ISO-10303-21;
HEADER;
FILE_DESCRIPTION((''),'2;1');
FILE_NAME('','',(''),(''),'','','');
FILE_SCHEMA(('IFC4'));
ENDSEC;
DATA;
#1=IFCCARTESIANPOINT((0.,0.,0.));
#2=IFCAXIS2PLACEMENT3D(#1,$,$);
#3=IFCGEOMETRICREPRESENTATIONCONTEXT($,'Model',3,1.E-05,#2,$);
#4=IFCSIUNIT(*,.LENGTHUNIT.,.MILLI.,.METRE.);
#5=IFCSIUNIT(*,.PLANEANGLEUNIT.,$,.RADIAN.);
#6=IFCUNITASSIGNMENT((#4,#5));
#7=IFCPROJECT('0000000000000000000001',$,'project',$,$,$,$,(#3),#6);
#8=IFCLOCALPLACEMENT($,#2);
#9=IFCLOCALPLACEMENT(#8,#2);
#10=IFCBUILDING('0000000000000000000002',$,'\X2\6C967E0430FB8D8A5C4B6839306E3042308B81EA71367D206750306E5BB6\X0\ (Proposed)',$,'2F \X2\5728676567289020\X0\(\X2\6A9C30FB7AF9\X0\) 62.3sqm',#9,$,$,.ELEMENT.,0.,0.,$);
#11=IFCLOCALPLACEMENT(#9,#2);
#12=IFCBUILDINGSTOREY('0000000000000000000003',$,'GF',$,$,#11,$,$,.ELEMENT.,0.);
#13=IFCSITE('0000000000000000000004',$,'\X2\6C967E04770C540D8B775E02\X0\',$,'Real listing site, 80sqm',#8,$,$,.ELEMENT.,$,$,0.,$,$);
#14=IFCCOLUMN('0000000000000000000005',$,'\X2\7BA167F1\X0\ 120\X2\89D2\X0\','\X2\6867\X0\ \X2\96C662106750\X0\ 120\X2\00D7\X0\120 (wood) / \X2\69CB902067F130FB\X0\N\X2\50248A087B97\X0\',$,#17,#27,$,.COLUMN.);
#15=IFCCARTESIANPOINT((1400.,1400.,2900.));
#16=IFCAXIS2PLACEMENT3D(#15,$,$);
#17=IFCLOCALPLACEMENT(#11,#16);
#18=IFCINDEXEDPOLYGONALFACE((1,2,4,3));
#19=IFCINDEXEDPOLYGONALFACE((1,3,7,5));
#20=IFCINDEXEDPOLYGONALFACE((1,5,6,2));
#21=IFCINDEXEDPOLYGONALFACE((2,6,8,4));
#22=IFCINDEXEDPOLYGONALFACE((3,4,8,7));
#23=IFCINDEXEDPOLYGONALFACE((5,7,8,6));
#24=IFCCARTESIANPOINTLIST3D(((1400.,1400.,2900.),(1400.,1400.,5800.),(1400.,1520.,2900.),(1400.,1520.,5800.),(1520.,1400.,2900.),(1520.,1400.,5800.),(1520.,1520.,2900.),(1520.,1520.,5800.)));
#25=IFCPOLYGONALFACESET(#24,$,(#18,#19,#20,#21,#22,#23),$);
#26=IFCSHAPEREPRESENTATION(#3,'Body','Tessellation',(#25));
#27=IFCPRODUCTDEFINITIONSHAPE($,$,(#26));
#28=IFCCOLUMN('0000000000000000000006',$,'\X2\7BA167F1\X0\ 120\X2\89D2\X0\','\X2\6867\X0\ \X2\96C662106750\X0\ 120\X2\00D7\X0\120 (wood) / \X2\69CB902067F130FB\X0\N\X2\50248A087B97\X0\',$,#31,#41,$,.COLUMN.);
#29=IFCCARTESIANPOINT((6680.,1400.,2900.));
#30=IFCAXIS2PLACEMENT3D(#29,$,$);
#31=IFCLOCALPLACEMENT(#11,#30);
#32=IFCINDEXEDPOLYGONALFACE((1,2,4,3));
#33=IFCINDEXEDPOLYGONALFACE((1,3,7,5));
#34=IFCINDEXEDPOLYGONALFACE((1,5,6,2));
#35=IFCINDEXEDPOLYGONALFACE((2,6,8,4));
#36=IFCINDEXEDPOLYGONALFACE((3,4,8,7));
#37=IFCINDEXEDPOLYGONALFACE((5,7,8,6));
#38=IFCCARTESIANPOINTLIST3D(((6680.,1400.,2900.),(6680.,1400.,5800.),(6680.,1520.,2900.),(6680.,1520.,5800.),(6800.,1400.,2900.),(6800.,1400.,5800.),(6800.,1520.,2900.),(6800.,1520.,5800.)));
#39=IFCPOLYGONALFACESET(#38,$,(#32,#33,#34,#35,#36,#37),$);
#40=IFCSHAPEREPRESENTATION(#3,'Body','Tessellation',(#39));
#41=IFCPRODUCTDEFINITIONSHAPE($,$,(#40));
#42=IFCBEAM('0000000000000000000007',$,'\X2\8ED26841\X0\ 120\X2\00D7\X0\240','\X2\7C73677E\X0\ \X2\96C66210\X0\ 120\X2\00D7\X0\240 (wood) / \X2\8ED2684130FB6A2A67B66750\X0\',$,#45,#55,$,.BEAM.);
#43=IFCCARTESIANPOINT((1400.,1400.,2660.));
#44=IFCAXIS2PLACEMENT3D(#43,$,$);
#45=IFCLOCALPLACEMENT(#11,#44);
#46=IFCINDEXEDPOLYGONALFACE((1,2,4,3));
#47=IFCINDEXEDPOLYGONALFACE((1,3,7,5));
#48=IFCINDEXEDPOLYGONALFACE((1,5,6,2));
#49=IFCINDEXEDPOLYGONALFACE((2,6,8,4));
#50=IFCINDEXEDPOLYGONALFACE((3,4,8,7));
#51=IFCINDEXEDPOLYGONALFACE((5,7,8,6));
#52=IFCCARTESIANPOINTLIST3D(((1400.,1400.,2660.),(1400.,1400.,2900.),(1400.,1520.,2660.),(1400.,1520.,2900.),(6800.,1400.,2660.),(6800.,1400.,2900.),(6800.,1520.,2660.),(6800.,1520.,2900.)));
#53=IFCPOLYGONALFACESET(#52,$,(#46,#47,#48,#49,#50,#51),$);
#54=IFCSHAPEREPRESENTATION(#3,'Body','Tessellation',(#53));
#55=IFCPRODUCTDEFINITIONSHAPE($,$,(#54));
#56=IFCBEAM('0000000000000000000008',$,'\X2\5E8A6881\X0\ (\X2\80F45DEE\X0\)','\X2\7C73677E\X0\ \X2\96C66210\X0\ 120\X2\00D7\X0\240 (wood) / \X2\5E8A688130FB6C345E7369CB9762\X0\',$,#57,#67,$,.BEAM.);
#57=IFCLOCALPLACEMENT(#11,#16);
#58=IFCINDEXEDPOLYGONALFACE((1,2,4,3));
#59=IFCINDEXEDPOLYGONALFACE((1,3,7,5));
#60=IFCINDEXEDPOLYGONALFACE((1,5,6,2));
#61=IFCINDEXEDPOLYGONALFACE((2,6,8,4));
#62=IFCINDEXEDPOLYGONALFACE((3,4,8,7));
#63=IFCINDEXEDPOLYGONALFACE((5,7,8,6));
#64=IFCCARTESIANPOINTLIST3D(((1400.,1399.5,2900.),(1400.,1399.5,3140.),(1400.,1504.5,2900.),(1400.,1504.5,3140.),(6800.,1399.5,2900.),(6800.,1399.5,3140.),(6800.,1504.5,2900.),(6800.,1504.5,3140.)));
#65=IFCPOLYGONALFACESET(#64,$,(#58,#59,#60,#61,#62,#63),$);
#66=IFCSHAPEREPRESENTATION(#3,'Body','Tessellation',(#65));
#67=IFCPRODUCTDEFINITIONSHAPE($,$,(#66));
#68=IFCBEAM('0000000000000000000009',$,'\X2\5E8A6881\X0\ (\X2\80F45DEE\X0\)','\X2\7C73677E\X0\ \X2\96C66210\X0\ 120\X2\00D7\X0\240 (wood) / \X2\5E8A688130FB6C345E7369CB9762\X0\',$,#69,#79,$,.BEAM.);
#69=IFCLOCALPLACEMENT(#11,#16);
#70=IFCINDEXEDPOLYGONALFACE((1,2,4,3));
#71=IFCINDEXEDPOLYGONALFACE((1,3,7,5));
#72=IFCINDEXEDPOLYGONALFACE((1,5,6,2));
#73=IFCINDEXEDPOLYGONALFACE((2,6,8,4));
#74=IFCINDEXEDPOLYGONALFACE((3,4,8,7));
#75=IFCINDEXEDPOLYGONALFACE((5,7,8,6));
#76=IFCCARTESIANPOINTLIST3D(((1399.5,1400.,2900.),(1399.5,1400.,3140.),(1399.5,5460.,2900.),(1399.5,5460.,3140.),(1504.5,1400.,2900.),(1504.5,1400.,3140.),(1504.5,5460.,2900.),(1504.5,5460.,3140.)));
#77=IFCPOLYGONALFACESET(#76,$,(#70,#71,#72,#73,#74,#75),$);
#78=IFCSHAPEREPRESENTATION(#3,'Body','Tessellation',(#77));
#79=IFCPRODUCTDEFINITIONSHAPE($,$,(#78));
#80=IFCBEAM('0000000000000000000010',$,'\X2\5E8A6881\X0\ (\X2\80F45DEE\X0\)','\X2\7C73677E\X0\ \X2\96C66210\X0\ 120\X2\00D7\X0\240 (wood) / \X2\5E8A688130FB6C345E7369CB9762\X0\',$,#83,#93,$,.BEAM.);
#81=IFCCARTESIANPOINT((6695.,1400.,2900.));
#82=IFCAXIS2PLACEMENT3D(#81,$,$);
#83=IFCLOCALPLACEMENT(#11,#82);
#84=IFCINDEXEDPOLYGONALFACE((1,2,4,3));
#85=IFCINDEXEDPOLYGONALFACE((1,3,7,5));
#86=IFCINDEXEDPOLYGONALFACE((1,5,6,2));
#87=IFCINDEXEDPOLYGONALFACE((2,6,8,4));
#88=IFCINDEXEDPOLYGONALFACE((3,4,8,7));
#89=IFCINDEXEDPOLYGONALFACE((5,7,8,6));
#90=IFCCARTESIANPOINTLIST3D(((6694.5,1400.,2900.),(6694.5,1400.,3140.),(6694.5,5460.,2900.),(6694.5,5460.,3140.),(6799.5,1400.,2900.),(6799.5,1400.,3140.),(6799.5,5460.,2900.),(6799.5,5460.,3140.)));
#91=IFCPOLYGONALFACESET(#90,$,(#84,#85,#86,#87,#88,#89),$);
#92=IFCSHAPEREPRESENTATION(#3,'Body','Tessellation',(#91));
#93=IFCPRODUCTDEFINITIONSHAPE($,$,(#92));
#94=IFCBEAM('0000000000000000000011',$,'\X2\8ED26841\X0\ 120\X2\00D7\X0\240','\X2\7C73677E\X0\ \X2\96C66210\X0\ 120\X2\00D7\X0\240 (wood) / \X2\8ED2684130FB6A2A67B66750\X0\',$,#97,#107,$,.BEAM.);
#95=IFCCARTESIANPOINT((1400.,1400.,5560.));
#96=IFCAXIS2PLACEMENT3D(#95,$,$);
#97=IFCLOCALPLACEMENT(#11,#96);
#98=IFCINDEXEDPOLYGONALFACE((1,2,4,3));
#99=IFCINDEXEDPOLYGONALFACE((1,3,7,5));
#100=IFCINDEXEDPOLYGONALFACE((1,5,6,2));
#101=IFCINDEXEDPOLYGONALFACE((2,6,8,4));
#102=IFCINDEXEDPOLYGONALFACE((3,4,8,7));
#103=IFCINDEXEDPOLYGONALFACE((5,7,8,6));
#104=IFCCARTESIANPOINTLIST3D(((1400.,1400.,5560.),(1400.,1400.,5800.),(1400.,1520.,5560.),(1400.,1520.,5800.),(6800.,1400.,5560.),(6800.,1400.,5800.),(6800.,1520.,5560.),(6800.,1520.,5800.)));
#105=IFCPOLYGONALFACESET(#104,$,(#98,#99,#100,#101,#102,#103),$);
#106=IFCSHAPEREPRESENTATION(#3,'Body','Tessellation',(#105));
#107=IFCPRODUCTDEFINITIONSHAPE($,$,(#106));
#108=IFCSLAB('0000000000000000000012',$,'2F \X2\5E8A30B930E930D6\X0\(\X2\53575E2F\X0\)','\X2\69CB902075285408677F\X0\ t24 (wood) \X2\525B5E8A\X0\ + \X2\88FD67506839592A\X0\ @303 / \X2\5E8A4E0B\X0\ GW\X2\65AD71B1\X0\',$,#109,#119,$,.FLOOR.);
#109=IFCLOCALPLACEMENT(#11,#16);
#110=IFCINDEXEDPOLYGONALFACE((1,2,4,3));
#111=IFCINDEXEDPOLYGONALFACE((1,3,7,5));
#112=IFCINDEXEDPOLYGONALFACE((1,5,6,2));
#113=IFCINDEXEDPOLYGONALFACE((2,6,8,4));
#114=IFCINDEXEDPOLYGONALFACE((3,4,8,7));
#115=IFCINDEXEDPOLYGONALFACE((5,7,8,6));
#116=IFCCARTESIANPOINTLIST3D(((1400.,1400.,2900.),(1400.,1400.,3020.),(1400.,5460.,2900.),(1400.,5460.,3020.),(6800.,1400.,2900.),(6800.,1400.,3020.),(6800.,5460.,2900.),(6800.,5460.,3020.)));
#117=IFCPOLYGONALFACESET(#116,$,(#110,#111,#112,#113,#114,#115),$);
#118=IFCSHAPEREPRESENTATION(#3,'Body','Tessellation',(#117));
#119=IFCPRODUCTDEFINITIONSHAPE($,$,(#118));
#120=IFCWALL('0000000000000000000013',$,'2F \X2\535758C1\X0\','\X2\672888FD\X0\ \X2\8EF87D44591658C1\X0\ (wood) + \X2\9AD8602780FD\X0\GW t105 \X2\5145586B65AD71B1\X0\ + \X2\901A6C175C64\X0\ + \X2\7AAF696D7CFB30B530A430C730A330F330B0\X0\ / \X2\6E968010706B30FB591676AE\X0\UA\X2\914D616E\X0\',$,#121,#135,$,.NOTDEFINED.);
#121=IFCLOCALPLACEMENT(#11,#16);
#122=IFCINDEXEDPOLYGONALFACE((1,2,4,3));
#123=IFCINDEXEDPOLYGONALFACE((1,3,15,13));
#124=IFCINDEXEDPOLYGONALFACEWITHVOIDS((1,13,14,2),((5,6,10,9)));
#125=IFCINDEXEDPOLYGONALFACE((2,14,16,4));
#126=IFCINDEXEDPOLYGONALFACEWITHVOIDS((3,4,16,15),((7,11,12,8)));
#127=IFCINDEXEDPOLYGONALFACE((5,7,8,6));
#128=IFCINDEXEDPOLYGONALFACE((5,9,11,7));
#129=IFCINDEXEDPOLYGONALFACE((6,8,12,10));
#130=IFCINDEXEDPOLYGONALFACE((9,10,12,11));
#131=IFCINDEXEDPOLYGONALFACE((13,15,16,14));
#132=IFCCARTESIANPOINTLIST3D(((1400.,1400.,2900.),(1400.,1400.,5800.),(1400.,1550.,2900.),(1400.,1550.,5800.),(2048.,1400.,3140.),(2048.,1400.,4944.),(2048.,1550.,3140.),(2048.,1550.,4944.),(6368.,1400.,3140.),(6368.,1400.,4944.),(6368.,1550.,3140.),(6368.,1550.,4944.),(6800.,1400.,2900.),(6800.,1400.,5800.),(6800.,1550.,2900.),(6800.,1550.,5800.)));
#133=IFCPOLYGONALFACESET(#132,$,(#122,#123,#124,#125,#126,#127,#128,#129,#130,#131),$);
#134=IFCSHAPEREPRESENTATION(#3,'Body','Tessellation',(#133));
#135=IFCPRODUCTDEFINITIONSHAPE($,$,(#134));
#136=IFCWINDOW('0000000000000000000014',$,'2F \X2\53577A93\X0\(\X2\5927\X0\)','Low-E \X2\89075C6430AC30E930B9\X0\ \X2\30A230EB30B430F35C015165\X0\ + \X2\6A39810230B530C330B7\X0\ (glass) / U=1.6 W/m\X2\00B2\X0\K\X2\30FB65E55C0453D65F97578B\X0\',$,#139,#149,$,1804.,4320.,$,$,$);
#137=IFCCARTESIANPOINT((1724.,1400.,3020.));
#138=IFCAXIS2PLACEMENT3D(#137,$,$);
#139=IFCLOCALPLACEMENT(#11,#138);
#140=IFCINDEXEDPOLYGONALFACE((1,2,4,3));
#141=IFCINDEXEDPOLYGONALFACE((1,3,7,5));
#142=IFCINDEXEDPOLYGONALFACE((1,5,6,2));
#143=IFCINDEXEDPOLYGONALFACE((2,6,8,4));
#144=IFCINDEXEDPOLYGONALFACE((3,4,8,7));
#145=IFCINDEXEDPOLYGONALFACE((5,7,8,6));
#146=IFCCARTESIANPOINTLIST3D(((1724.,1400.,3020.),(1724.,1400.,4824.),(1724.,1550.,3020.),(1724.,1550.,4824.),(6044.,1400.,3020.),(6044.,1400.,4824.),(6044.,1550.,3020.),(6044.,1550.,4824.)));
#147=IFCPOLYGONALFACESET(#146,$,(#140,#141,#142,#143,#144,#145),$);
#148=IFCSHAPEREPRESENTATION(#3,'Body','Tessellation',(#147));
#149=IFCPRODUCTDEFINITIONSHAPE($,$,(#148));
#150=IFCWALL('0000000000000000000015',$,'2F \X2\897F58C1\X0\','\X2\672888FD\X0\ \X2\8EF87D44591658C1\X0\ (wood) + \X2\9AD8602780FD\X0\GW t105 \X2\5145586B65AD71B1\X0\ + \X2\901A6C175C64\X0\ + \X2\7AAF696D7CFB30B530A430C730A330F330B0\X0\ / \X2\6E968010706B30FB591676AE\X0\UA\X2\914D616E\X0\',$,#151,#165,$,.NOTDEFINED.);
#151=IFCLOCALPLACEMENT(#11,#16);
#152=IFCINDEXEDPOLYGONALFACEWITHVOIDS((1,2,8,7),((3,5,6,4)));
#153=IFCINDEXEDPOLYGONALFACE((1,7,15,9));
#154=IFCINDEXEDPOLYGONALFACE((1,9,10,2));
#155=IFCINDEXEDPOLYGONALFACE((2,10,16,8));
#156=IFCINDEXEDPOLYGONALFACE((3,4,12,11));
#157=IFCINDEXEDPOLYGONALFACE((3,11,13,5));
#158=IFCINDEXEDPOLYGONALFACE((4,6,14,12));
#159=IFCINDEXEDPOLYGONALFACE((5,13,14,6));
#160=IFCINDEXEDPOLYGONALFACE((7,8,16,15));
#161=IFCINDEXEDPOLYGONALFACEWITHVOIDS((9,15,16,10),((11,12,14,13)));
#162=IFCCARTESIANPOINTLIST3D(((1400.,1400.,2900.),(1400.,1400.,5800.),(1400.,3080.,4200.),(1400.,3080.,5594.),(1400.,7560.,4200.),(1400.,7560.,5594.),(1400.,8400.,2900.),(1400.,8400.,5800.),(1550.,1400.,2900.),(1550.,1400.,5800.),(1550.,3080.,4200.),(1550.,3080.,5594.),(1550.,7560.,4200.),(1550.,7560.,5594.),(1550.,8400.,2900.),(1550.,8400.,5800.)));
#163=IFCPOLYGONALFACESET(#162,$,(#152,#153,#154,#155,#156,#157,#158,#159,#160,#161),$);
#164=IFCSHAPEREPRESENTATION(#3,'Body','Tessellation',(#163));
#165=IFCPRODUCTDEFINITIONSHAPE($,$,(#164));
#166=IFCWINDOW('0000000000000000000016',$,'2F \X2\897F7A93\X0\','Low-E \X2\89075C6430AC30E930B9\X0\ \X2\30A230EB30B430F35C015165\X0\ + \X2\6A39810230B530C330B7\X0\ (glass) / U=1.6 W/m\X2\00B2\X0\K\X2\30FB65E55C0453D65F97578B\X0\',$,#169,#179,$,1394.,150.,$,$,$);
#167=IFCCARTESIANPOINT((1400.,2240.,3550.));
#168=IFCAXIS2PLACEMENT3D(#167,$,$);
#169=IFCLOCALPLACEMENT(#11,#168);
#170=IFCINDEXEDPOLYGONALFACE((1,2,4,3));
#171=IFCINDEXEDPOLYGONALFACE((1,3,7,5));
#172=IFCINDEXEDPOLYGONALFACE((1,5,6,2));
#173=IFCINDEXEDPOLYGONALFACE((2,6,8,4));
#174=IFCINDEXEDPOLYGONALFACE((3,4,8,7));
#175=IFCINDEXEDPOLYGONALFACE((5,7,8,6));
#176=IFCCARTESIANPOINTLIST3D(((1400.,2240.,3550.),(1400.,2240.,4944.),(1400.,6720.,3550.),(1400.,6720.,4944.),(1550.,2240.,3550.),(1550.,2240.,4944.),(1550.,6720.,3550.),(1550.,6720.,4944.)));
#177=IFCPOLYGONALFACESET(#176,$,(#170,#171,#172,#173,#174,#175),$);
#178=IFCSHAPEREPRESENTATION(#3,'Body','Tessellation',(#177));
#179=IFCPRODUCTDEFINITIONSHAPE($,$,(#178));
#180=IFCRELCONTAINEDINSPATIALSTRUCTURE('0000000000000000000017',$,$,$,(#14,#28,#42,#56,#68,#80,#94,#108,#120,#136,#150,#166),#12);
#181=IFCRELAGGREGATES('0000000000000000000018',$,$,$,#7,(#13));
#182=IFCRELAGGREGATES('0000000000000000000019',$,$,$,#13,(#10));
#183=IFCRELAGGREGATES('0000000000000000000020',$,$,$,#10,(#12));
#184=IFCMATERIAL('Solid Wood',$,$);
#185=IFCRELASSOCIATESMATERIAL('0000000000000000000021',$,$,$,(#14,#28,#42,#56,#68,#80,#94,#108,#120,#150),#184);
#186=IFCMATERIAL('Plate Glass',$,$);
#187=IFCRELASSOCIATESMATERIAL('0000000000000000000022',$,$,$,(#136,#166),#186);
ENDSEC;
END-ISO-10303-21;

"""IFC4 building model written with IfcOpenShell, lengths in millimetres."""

from ifc_helpers import new_model, si_unit, frame, frame_2d, origin, place, context, project, spatial, rectangle, extrude, material, element, fill, save


model = new_model("IFC4")

# Units and contexts
model_context = context("Model", 3, precision=1e-05, world=origin())
ifc_project = project(units=[si_unit("LENGTHUNIT", "METRE", prefix="MILLI"), si_unit("PLANEANGLEUNIT", "RADIAN")], contexts=[model_context])

# Site, building, storey
site_placement = place(None, origin())
site = spatial("IfcSite", under=ifc_project, at=site_placement, Name="沖縄県名護市", ObjectType="Real listing site, 80sqm", CompositionType="ELEMENT", RefElevation=0.0)
building_placement = place(site_placement, origin())
building = spatial("IfcBuilding", under=site, at=building_placement, Name="沖縄・越屋根のある自然素材の家 (Proposed)", ObjectType="2F 在来木造(檜・竹) 62.3sqm", CompositionType="ELEMENT", ElevationOfRefHeight=0.0, ElevationOfTerrain=0.0)
storey_placement = place(building_placement, origin())
storey = spatial("IfcBuildingStorey", under=building, at=storey_placement, Name="GF", CompositionType="ELEMENT", Elevation=0.0)

# Columns
ifc_material_1 = material(Name="Solid Wood")
column_1_placement = place(storey_placement, frame((1400.0, 1400.0, 2900.0)))
element("IfcColumn", 1, at=column_1_placement, inside=storey, material=ifc_material_1, Name="管柱 120角", Description="桧 集成材 120×120 (wood) / 構造柱・N値計算", PredefinedType="COLUMN", context=model_context, shape_type="SweptSolid", body=[
    extrude(rectangle(XDim=120.0, YDim=120.0, at=frame_2d((60.0, 60.0))), frame((1400.0, 1400.0, 2900.0)), (0.0, 0.0, 1.0), 2900.0),
])
column_2_placement = place(storey_placement, frame((6680.0, 1400.0, 2900.0)))
element("IfcColumn", 2, at=column_2_placement, inside=storey, material=ifc_material_1, Name="管柱 120角", Description="桧 集成材 120×120 (wood) / 構造柱・N値計算", PredefinedType="COLUMN", context=model_context, shape_type="SweptSolid", body=[
    extrude(rectangle(XDim=120.0, YDim=120.0, at=frame_2d((60.0, 60.0))), frame((6680.0, 1400.0, 2900.0)), (0.0, 0.0, 1.0), 2900.0),
])

# Beams
beam_1_placement = place(storey_placement, frame((1400.0, 1400.0, 2660.0)))
element("IfcBeam", 3, at=beam_1_placement, inside=storey, material=ifc_material_1, Name="軒桁 120×240", Description="米松 集成 120×240 (wood) / 軒桁・横架材", PredefinedType="BEAM", context=model_context, shape_type="SweptSolid", body=[
    extrude(rectangle(XDim=5400.0, YDim=120.0, at=frame_2d((2700.0, 60.0))), frame((1400.0, 1400.0, 2660.0)), (0.0, 0.0, 1.0), 240.0),
])
beam_2_placement = place(storey_placement, frame((1400.0, 1400.0, 2900.0)))
element("IfcBeam", 4, at=beam_2_placement, inside=storey, material=ifc_material_1, Name="床梁 (胴差)", Description="米松 集成 120×240 (wood) / 床梁・水平構面", PredefinedType="BEAM", context=model_context, shape_type="SweptSolid", body=[
    extrude(rectangle(XDim=5400.0, YDim=105.0, at=frame_2d((2700.0, 52.0))), frame((1400.0, 1400.0, 2900.0)), (0.0, 0.0, 1.0), 240.0),
])
beam_3_placement = place(storey_placement, frame((1400.0, 1400.0, 2900.0)))
element("IfcBeam", 5, at=beam_3_placement, inside=storey, material=ifc_material_1, Name="床梁 (胴差)", Description="米松 集成 120×240 (wood) / 床梁・水平構面", PredefinedType="BEAM", context=model_context, shape_type="SweptSolid", body=[
    extrude(rectangle(XDim=105.0, YDim=4060.0, at=frame_2d((52.0, 2030.0))), frame((1400.0, 1400.0, 2900.0)), (0.0, 0.0, 1.0), 240.0),
])
beam_4_placement = place(storey_placement, frame((6695.0, 1400.0, 2900.0)))
element("IfcBeam", 6, at=beam_4_placement, inside=storey, material=ifc_material_1, Name="床梁 (胴差)", Description="米松 集成 120×240 (wood) / 床梁・水平構面", PredefinedType="BEAM", context=model_context, shape_type="SweptSolid", body=[
    extrude(rectangle(XDim=105.0, YDim=4060.0, at=frame_2d((52.0, 2030.0))), frame((6695.0, 1400.0, 2900.0)), (0.0, 0.0, 1.0), 240.0),
])
beam_5_placement = place(storey_placement, frame((1400.0, 1400.0, 5560.0)))
element("IfcBeam", 7, at=beam_5_placement, inside=storey, material=ifc_material_1, Name="軒桁 120×240", Description="米松 集成 120×240 (wood) / 軒桁・横架材", PredefinedType="BEAM", context=model_context, shape_type="SweptSolid", body=[
    extrude(rectangle(XDim=5400.0, YDim=120.0, at=frame_2d((2700.0, 60.0))), frame((1400.0, 1400.0, 5560.0)), (0.0, 0.0, 1.0), 240.0),
])

# Slab
slab_placement = place(storey_placement, frame((1400.0, 1400.0, 2900.0)))
element("IfcSlab", 8, at=slab_placement, inside=storey, material=ifc_material_1, Name="2F 床スラブ(南帯)", Description="構造用合板 t24 (wood) 剛床 + 製材根太 @303 / 床下 GW断熱", PredefinedType="FLOOR", context=model_context, shape_type="SweptSolid", body=[
    extrude(rectangle(XDim=5400.0, YDim=4060.0, at=frame_2d((2700.0, 2030.0))), frame((1400.0, 1400.0, 2900.0)), (0.0, 0.0, 1.0), 120.0),
])

# Walls, openings, windows
wall_1_placement = place(storey_placement, frame((1400.0, 1400.0, 2900.0)))
wall_1 = element("IfcWall", 9, at=wall_1_placement, inside=storey, material=ifc_material_1, Name="2F 南壁", Description="木製 軸組外壁 (wood) + 高性能GW t105 充填断熱 + 通気層 + 窯業系サイディング / 準耐火・外皮UA配慮", PredefinedType="NOTDEFINED", context=model_context, shape_type="SweptSolid", body=[
    extrude(rectangle(XDim=5400.0, YDim=150.0, at=frame_2d((2700.0, 75.0))), frame((1400.0, 1400.0, 2900.0)), (0.0, 0.0, 1.0), 2900.0),
])
opening_1_placement = place(storey_placement, frame((1724.0, 1400.0, 3020.0)))
opening_1 = element("IfcOpeningElement", 10, at=opening_1_placement, cuts=wall_1, PredefinedType="NOTDEFINED", context=model_context, shape_type="SweptSolid", body=[
    extrude(rectangle(XDim=4320.0, YDim=150.0, at=frame_2d((2160.0, 75.0))), frame((1724.0, 1400.0, 3020.0)), (0.0, 0.0, 1.0), 1804.0),
])
ifc_material_2 = material(Name="Plate Glass")
window_1_placement = place(storey_placement, frame((1724.0, 1400.0, 3020.0)))
window_1 = element("IfcWindow", 11, at=window_1_placement, inside=storey, material=ifc_material_2, Name="2F 南窓(大)", Description="Low-E 複層ガラス アルゴン封入 + 樹脂サッシ (glass) / U=1.6 W/m²K・日射取得型", OverallHeight=1804.0, OverallWidth=4320.0, context=model_context, shape_type="SweptSolid", body=[
    extrude(rectangle(XDim=4320.0, YDim=150.0, at=frame_2d((2160.0, 75.0))), frame((1724.0, 1400.0, 3020.0)), (0.0, 0.0, 1.0), 1804.0),
])
fill(opening_1, window_1)
wall_2_placement = place(storey_placement, frame((1400.0, 1400.0, 2900.0)))
wall_2 = element("IfcWall", 12, at=wall_2_placement, inside=storey, material=ifc_material_1, Name="2F 西壁", Description="木製 軸組外壁 (wood) + 高性能GW t105 充填断熱 + 通気層 + 窯業系サイディング / 準耐火・外皮UA配慮", PredefinedType="NOTDEFINED", context=model_context, shape_type="SweptSolid", body=[
    extrude(rectangle(XDim=150.0, YDim=7000.0, at=frame_2d((75.0, 3500.0))), frame((1400.0, 1400.0, 2900.0)), (0.0, 0.0, 1.0), 2900.0),
])
opening_2_placement = place(storey_placement, frame((1400.0, 2240.0, 3550.0)))
opening_2 = element("IfcOpeningElement", 13, at=opening_2_placement, cuts=wall_2, PredefinedType="NOTDEFINED", context=model_context, shape_type="SweptSolid", body=[
    extrude(rectangle(XDim=150.0, YDim=4480.0, at=frame_2d((75.0, 2240.0))), frame((1400.0, 2240.0, 3550.0)), (0.0, 0.0, 1.0), 1394.0),
])
window_2_placement = place(storey_placement, frame((1400.0, 2240.0, 3550.0)))
window_2 = element("IfcWindow", 14, at=window_2_placement, inside=storey, material=ifc_material_2, Name="2F 西窓", Description="Low-E 複層ガラス アルゴン封入 + 樹脂サッシ (glass) / U=1.6 W/m²K・日射取得型", OverallHeight=1394.0, OverallWidth=150.0, context=model_context, shape_type="SweptSolid", body=[
    extrude(rectangle(XDim=150.0, YDim=4480.0, at=frame_2d((75.0, 2240.0))), frame((1400.0, 2240.0, 3550.0)), (0.0, 0.0, 1.0), 1394.0),
])
fill(opening_2, window_2)

save(model, "model.ifc")
